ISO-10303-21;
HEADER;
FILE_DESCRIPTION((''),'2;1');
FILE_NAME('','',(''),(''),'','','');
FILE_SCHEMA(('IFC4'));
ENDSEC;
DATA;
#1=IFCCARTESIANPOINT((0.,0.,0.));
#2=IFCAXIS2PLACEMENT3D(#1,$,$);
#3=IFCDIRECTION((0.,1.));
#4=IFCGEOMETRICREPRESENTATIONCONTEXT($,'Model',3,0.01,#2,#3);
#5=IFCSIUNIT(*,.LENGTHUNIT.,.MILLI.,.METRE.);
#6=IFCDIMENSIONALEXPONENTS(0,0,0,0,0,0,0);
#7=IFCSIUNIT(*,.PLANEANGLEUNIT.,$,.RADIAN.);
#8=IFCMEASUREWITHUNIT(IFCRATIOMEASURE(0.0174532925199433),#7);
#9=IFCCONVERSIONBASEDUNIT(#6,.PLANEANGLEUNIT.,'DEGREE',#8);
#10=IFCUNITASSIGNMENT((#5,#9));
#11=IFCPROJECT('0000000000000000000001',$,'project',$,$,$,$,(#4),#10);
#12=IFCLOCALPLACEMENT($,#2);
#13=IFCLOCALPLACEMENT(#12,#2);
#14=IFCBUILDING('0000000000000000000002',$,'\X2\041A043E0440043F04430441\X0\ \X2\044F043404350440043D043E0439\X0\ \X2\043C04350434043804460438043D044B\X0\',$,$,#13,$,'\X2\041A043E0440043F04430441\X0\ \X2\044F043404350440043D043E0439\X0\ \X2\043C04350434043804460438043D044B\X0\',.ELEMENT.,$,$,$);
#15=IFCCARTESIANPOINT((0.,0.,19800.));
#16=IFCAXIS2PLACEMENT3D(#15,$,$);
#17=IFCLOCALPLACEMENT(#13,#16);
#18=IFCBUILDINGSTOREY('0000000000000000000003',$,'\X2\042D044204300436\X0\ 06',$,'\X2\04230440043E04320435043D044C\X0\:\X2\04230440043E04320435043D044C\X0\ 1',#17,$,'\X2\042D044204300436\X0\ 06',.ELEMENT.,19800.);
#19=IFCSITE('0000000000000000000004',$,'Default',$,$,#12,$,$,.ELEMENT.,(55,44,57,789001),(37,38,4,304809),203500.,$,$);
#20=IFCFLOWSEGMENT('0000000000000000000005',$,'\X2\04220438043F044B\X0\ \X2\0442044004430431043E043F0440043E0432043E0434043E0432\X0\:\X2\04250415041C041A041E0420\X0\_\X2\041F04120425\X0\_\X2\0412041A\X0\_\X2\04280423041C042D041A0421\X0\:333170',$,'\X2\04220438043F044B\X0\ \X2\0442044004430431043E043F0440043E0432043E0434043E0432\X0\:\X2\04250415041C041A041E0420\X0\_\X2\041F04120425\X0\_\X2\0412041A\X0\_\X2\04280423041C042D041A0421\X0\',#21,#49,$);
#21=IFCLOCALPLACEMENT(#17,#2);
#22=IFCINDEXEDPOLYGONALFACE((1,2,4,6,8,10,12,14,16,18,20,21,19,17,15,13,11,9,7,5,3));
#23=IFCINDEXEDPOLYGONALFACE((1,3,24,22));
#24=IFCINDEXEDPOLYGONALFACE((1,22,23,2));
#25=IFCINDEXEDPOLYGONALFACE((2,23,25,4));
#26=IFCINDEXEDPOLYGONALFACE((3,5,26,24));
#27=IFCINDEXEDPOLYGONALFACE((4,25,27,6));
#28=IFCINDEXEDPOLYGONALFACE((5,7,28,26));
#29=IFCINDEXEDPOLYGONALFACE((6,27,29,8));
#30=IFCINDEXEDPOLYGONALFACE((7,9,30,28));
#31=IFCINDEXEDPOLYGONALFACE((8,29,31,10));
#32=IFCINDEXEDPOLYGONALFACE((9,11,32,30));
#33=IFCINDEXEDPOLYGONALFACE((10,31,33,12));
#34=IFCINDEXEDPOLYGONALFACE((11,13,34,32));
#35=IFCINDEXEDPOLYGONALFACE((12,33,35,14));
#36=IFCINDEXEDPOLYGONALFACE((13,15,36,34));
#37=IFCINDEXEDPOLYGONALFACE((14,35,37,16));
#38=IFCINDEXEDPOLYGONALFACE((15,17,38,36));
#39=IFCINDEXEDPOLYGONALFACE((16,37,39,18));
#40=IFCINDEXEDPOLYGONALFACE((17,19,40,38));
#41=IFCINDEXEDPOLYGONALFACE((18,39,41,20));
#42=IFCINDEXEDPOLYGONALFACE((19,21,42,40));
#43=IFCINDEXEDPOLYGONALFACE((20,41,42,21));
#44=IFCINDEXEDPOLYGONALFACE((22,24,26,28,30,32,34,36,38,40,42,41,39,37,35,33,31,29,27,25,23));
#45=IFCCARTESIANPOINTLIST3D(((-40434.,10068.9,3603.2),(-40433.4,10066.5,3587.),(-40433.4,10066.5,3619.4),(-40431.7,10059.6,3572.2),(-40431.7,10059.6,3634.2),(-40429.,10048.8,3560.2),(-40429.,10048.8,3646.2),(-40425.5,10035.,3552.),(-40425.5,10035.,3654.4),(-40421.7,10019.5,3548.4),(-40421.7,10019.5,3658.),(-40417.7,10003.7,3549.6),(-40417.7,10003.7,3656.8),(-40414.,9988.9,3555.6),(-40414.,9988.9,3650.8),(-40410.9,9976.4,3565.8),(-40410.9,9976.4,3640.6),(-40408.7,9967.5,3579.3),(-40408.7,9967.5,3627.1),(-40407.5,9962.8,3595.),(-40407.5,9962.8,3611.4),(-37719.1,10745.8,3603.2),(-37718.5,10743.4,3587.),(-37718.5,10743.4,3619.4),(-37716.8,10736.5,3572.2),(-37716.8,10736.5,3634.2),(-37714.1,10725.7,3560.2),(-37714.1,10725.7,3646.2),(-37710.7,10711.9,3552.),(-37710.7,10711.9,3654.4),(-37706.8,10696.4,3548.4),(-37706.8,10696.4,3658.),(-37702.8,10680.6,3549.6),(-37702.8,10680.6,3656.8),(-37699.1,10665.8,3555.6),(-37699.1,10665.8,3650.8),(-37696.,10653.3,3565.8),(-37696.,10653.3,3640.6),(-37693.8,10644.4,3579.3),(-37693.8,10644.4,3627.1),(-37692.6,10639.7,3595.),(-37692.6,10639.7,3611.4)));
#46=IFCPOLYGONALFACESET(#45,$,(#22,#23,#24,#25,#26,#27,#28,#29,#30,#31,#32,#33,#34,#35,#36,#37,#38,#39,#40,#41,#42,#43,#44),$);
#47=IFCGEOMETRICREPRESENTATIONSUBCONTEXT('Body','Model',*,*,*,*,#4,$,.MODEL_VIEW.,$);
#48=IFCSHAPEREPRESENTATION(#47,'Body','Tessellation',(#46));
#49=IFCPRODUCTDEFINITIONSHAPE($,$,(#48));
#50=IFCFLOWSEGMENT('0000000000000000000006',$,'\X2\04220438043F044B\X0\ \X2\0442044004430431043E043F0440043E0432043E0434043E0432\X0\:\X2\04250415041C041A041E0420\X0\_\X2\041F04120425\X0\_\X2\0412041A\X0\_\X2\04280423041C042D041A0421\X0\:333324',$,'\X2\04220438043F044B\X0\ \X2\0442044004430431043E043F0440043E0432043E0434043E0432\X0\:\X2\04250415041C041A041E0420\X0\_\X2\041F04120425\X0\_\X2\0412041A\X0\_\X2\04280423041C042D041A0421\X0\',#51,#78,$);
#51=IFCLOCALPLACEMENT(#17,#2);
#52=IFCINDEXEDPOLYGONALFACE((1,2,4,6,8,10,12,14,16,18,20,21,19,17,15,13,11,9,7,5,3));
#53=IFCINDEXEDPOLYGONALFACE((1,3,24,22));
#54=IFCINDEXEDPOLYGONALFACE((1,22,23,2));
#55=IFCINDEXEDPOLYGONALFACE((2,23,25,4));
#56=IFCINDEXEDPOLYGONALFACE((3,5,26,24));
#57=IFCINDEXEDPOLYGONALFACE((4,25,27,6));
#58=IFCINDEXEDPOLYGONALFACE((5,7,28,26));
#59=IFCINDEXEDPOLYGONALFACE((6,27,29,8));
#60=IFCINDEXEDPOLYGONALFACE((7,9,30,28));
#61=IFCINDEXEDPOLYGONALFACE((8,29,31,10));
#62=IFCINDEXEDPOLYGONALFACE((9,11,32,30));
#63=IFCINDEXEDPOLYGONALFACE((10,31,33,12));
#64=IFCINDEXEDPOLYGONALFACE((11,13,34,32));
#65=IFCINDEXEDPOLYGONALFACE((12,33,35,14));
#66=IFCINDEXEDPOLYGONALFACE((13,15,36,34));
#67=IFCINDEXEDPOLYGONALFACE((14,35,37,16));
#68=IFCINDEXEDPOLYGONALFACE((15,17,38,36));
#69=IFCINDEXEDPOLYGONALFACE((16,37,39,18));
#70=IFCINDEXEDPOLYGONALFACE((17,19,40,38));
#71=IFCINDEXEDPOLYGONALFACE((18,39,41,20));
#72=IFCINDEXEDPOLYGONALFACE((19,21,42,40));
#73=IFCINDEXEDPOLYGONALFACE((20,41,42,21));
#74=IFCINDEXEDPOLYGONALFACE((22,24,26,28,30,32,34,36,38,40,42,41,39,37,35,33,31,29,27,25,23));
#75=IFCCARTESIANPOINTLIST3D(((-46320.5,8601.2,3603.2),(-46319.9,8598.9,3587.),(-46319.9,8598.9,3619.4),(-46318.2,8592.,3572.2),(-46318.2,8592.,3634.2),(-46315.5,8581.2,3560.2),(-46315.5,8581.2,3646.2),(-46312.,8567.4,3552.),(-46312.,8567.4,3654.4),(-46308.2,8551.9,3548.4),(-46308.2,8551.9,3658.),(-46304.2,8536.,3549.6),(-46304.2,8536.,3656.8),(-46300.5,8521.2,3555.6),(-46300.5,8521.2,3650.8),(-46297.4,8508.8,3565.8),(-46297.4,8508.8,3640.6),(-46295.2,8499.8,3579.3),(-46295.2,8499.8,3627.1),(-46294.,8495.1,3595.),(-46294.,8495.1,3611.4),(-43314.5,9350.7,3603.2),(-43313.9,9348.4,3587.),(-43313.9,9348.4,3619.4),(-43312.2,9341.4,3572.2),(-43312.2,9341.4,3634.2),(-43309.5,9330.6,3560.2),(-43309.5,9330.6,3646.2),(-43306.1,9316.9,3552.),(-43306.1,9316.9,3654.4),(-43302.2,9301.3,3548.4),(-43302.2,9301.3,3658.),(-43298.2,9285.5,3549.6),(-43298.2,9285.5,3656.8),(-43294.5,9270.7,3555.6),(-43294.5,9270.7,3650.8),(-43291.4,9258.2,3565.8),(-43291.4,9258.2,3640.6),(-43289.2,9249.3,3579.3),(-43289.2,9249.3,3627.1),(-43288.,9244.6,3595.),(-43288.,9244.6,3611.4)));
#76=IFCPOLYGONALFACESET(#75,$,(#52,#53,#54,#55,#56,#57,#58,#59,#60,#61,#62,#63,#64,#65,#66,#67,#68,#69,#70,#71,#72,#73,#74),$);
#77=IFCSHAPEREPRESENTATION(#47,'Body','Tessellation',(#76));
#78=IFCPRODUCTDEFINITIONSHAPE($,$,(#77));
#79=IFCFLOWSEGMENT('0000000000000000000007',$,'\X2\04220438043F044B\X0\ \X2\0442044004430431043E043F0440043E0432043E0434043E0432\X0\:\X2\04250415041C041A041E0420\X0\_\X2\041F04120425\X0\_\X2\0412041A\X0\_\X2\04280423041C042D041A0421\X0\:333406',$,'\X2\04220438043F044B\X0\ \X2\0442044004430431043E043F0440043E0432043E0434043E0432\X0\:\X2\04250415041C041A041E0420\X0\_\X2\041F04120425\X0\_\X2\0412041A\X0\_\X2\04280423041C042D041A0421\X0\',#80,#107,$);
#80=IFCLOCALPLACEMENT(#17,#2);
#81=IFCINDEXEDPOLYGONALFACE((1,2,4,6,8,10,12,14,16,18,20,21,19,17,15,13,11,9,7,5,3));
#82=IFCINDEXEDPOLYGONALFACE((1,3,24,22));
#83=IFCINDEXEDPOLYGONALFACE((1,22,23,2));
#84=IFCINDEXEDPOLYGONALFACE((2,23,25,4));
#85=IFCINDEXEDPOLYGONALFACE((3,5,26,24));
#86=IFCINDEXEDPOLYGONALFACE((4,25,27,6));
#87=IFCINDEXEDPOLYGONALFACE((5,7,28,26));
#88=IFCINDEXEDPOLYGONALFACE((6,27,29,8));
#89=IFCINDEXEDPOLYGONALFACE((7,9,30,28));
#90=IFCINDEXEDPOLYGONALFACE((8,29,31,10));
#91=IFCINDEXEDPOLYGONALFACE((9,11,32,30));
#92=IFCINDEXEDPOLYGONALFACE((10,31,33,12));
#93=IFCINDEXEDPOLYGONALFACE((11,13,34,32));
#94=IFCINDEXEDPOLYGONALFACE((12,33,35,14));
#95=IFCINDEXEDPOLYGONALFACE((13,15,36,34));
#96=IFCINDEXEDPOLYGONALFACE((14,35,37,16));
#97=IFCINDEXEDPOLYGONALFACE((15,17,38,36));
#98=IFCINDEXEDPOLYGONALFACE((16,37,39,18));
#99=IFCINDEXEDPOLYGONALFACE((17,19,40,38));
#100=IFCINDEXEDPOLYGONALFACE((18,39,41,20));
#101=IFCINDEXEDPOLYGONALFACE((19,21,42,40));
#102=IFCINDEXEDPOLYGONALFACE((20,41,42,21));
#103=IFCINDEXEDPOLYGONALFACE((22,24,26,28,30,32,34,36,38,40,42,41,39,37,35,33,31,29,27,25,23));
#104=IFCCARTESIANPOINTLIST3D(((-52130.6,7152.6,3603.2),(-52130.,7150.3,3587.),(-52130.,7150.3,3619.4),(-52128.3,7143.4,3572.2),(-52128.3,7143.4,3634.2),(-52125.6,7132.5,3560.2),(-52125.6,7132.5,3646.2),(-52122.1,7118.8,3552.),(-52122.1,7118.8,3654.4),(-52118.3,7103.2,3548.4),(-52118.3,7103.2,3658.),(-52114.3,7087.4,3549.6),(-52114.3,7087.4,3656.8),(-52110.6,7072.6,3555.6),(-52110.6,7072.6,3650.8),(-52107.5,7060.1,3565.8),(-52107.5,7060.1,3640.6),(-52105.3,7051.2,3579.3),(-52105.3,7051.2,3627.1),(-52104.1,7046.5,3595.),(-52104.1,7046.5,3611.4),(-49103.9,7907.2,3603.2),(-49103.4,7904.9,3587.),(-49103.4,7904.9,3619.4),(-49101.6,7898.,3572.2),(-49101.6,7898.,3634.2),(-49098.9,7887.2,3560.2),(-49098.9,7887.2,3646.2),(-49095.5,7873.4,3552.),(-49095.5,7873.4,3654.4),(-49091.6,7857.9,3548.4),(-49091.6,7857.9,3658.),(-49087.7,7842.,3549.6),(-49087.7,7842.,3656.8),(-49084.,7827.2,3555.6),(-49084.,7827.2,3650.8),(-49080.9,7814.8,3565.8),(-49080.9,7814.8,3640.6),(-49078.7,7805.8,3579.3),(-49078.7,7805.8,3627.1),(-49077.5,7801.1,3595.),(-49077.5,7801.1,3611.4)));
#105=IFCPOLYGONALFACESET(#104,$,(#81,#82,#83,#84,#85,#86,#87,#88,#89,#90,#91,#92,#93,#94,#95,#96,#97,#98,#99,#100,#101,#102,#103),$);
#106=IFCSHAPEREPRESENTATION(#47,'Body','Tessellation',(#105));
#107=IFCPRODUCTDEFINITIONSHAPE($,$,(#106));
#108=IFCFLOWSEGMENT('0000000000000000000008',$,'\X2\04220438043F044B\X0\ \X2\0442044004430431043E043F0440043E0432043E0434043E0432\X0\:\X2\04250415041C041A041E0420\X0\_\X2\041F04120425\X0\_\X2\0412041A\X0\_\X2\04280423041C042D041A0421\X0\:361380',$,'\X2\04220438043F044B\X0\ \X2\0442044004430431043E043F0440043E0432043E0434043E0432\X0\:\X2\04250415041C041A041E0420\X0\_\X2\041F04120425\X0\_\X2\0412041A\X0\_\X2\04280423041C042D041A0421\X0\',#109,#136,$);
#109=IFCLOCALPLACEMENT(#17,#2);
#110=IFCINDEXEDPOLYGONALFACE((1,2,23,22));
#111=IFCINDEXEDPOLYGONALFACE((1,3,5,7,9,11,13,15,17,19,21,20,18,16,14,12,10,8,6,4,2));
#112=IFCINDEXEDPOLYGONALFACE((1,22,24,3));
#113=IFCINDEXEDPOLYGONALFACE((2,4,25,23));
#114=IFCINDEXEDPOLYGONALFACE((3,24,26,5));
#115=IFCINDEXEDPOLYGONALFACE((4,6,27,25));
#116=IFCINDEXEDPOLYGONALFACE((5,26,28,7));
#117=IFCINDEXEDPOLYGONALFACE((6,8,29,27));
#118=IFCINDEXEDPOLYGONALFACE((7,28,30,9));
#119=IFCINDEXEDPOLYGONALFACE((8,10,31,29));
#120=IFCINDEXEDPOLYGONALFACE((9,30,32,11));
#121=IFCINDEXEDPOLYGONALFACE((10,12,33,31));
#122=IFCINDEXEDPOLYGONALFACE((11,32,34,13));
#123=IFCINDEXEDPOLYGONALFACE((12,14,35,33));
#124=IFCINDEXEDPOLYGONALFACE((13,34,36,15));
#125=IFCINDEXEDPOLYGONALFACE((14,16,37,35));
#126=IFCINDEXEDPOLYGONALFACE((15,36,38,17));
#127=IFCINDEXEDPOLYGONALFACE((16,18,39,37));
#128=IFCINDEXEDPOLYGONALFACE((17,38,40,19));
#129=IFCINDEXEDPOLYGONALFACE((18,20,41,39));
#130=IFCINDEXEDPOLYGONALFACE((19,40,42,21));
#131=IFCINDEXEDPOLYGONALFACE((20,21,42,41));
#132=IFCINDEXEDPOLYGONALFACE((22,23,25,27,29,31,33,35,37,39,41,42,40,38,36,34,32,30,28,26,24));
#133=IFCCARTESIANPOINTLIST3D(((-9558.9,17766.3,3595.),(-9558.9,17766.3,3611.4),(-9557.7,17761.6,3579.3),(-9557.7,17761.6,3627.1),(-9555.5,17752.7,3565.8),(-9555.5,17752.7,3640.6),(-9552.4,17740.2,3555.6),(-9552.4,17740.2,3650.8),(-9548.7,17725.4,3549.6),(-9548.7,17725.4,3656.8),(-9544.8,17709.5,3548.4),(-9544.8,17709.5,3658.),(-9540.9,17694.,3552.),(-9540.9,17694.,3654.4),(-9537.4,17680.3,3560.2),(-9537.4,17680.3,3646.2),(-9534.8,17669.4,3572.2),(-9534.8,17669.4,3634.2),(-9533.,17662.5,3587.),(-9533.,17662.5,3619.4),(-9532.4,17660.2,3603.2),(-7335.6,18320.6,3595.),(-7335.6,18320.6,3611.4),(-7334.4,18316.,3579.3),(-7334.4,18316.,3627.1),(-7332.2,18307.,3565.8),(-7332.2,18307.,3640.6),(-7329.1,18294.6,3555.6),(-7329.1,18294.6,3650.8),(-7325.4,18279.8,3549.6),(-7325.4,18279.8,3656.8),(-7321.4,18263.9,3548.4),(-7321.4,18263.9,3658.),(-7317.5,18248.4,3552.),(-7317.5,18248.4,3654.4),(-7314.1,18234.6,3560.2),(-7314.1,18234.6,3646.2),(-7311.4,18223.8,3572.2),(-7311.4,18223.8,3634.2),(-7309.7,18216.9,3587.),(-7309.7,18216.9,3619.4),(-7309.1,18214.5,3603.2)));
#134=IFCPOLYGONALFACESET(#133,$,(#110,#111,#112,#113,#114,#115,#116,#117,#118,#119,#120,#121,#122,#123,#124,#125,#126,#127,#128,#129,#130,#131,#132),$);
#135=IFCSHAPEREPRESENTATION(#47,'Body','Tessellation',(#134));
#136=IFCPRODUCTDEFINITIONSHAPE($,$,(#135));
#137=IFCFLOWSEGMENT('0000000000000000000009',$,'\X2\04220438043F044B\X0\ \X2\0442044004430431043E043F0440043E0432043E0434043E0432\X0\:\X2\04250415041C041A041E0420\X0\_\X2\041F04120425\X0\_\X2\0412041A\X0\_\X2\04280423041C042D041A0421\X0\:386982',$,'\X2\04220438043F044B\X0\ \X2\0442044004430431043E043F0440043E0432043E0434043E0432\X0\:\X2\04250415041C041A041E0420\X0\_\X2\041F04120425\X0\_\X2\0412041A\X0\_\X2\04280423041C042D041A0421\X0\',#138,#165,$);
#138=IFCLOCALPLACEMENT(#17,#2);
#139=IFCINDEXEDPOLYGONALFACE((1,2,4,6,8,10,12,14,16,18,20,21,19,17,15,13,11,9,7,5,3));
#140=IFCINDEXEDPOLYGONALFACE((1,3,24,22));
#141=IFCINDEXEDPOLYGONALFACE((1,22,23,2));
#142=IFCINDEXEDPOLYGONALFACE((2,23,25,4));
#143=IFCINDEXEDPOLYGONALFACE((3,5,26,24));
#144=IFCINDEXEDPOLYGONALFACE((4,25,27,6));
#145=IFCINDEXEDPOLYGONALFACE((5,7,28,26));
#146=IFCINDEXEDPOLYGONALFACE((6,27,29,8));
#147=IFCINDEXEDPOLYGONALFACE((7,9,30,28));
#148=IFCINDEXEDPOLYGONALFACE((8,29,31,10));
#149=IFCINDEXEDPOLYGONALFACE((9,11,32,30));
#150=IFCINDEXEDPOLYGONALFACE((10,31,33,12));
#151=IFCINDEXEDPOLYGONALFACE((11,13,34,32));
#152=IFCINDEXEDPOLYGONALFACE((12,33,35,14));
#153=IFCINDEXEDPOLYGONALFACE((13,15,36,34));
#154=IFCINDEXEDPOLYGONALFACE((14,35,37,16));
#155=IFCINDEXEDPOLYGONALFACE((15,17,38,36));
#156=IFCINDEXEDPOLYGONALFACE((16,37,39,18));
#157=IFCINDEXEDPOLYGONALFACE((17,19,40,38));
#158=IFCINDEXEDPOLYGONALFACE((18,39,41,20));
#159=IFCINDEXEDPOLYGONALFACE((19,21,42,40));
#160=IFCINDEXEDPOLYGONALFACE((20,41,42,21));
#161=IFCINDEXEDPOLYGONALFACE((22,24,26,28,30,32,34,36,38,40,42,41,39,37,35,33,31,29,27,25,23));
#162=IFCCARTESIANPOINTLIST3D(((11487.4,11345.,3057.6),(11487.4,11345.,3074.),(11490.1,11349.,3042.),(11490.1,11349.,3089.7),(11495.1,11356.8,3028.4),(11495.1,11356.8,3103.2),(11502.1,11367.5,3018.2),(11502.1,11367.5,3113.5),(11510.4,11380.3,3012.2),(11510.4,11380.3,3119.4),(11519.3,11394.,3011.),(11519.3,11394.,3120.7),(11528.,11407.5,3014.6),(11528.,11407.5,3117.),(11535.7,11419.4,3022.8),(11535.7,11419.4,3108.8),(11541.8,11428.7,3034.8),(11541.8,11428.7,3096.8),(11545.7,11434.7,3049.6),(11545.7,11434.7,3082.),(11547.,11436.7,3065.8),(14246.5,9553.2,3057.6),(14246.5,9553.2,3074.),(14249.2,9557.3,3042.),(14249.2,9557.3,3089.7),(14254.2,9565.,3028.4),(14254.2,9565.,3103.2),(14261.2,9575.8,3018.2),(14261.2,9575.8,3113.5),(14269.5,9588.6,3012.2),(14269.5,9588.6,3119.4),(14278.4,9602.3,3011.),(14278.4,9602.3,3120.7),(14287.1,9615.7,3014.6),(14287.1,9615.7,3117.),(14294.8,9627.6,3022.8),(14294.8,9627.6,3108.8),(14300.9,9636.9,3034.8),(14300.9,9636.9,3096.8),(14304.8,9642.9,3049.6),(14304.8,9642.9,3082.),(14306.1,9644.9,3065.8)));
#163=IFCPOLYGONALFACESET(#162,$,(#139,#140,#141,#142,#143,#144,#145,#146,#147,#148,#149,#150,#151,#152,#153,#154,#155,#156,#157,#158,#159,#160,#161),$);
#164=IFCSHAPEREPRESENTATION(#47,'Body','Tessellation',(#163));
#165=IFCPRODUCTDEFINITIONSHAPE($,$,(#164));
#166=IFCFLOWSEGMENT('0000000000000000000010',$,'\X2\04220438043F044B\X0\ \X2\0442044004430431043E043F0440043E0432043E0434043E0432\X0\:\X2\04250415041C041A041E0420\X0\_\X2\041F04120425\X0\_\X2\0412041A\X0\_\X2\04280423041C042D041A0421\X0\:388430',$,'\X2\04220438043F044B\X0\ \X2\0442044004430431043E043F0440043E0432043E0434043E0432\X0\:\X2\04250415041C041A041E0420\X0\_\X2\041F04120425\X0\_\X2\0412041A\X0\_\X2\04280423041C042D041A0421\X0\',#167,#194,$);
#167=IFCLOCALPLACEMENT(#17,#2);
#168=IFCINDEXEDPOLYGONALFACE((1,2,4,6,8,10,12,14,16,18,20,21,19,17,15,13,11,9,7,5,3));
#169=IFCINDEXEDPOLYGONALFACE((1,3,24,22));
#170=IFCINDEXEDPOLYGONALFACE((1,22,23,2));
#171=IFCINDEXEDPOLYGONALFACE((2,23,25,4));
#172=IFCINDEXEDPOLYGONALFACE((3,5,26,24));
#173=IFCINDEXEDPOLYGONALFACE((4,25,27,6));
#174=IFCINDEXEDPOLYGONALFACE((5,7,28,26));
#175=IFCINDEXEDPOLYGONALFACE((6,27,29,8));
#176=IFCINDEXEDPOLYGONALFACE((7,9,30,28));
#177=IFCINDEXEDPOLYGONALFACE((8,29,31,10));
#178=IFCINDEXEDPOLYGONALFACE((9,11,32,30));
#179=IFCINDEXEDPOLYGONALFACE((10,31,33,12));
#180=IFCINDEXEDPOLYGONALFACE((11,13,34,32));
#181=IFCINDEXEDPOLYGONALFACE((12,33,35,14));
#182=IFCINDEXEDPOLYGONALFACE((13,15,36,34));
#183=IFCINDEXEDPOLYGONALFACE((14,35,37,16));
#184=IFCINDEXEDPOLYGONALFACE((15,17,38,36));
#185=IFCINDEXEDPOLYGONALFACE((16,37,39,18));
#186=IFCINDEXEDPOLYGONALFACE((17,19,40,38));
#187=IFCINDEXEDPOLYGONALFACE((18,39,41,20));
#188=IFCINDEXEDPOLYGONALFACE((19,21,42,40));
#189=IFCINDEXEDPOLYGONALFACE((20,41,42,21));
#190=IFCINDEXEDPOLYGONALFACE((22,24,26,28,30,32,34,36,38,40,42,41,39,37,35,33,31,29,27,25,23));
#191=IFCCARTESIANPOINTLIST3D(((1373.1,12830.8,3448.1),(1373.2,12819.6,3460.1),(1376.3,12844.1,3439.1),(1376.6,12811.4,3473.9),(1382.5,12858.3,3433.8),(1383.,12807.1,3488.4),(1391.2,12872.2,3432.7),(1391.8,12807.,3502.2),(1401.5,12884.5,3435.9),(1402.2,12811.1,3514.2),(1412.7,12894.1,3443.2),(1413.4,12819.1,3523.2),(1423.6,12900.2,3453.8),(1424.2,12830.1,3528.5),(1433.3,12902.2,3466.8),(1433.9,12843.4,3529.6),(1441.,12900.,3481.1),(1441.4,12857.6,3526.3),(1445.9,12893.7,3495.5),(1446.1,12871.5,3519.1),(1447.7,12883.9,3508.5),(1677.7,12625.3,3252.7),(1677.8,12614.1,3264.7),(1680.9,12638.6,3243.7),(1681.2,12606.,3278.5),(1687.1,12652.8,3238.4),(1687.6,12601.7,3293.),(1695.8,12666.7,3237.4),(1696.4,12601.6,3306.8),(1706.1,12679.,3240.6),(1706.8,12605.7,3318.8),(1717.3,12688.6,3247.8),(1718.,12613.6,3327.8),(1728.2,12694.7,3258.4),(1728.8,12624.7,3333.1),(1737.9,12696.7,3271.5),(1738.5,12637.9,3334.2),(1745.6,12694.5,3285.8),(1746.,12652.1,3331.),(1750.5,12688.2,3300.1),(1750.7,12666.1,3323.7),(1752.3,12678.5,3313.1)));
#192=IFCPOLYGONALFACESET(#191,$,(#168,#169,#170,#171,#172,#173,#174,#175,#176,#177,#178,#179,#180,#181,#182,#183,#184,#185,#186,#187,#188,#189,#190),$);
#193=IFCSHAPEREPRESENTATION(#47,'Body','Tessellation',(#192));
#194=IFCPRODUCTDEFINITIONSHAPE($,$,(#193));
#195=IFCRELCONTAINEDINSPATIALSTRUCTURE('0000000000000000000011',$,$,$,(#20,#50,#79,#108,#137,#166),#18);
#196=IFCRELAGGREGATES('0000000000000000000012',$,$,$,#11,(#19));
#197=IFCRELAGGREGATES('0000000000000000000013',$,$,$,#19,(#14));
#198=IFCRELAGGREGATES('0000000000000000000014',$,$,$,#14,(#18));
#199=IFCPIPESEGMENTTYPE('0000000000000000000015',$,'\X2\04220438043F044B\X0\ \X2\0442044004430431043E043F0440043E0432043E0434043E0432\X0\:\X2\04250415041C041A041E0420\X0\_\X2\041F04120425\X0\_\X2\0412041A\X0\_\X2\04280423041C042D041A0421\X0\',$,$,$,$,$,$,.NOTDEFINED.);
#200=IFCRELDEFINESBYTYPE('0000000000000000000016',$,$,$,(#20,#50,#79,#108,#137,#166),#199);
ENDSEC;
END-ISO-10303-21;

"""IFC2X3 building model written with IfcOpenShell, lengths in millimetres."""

from ifc_helpers import new_model, entity, si_unit, converted_unit, direction, frame, frame_2d, origin, origin_2d_with_axis, place, context, subcontext, project, spatial, circle, extrude, type_object, element, save


model = new_model("IFC2X3")

# Units and contexts
model_context = context("Model", 3, precision=0.01, world=origin(), true_north=direction((0.0, 1.0)))
body_context = subcontext(model_context, "Body", "Model", "MODEL_VIEW")
ifc_project = project(units=[si_unit("LENGTHUNIT", "METRE", prefix="MILLI"), converted_unit("PLANEANGLEUNIT", "DEGREE", entity("IfcRatioMeasure", 0.0174532925199433), si_unit("PLANEANGLEUNIT", "RADIAN"), dimensions=[0, 0, 0, 0, 0, 0, 0])], contexts=[model_context])

# Site, building, storey
site_placement = place(None, frame((0.0, 0.0, 0.0)))
site = spatial("IfcSite", under=ifc_project, at=site_placement, Name="Default", CompositionType="ELEMENT", RefLatitude=(55, 44, 57, 789001), RefLongitude=(37, 38, 4, 304809), RefElevation=203500.0)
building_placement = place(site_placement, origin())
building = spatial("IfcBuilding", under=site, at=building_placement, Name="Корпус ядерной медицины", LongName="Корпус ядерной медицины", CompositionType="ELEMENT")
storey_placement = place(building_placement, frame((0.0, 0.0, 19800.0)))
storey = spatial("IfcBuildingStorey", under=building, at=storey_placement, Name="Этаж 06", ObjectType="Уровень:Уровень 1", LongName="Этаж 06", CompositionType="ELEMENT", Elevation=19800.0)

# Flow segments
pipe_segment_type = type_object("IfcPipeSegmentType", Name="Типы трубопроводов:ХЕМКОР_ПВХ_ВК_ШУМЭКС", PredefinedType="NOTDEFINED")
flow_segment_1_placement = place(storey_placement, frame((-40435.6, 9960.6, 3546.6)))
element("IfcFlowSegment", 1, at=flow_segment_1_placement, inside=storey, type_object=pipe_segment_type, Name="Типы трубопроводов:ХЕМКОР_ПВХ_ВК_ШУМЭКС:333170", ObjectType="Типы трубопроводов:ХЕМКОР_ПВХ_ВК_ШУМЭКС", context=body_context, shape_type="SweptSolid", body=[
    extrude(circle(Radius=55.0, at=origin_2d_with_axis()), frame((14.9, 55.0, 56.6), z_axis=(0.970296, 0.241922, 0.0), x_axis=(-0.241922, 0.970296, 0.0)), (0.0, 0.0, 1.0), 2798.0),
])
flow_segment_2_placement = place(storey_placement, frame((-46322.1, 8492.9, 3546.6)))
element("IfcFlowSegment", 2, at=flow_segment_2_placement, inside=storey, type_object=pipe_segment_type, Name="Типы трубопроводов:ХЕМКОР_ПВХ_ВК_ШУМЭКС:333324", ObjectType="Типы трубопроводов:ХЕМКОР_ПВХ_ВК_ШУМЭКС", context=body_context, shape_type="SweptSolid", body=[
    extrude(circle(Radius=55.0, at=frame_2d((0.0, 0.0), x_axis=(1.0, 0.0))), frame((14.9, 55.0, 56.6), z_axis=(0.970296, 0.241922, 0.0), x_axis=(-0.241922, 0.970296, 0.0)), (0.0, 0.0, 1.0), 3098.0),
])
flow_segment_3_placement = place(storey_placement, frame((-52132.2, 7044.3, 3546.6)))
element("IfcFlowSegment", 3, at=flow_segment_3_placement, inside=storey, type_object=pipe_segment_type, Name="Типы трубопроводов:ХЕМКОР_ПВХ_ВК_ШУМЭКС:333406", ObjectType="Типы трубопроводов:ХЕМКОР_ПВХ_ВК_ШУМЭКС", context=body_context, shape_type="SweptSolid", body=[
    extrude(circle(Radius=55.0, at=origin_2d_with_axis()), frame((14.9, 55.0, 56.6), z_axis=(0.970296, 0.241922, 0.0), x_axis=(-0.241922, 0.970296, 0.0)), (0.0, 0.0, 1.0), 3119.3),
])
flow_segment_4_placement = place(storey_placement, frame((-9560.6, 17658.6, 3546.6)))
element("IfcFlowSegment", 4, at=flow_segment_4_placement, inside=storey, type_object=pipe_segment_type, Name="Типы трубопроводов:ХЕМКОР_ПВХ_ВК_ШУМЭКС:361380", ObjectType="Типы трубопроводов:ХЕМКОР_ПВХ_ВК_ШУМЭКС", context=body_context, shape_type="SweptSolid", body=[
    extrude(circle(Radius=55.0, at=origin_2d_with_axis()), frame((14.9, 55.0, 56.6), z_axis=(0.970296, 0.241922, 0.0), x_axis=(0.241922, -0.970296, 0.0)), (0.0, 0.0, 1.0), 2291.4),
])
flow_segment_5_placement = place(storey_placement, frame((11485.5, 9551.1, 3009.2)))
element("IfcFlowSegment", 5, at=flow_segment_5_placement, inside=storey, type_object=pipe_segment_type, Name="Типы трубопроводов:ХЕМКОР_ПВХ_ВК_ШУМЭКС:386982", ObjectType="Типы трубопроводов:ХЕМКОР_ПВХ_ВК_ШУМЭКС", context=body_context, shape_type="SweptSolid", body=[
    extrude(circle(Radius=55.0, at=origin_2d_with_axis()), frame((2790.7, 47.7, 56.6), z_axis=(-0.838671, 0.544639, 0.0), x_axis=(0.544639, 0.838671, 0.0)), (0.0, 0.0, 1.0), 3289.9),
])
flow_segment_6_placement = place(storey_placement, frame((1371.3, 12599.5, 3235.6)))
element("IfcFlowSegment", 6, at=flow_segment_6_placement, inside=storey, type_object=pipe_segment_type, Name="Типы трубопроводов:ХЕМКОР_ПВХ_ВК_ШУМЭКС:388430", ObjectType="Типы трубопроводов:ХЕМКОР_ПВХ_ВК_ШУМЭКС", context=body_context, shape_type="SweptSolid", body=[
    extrude(circle(Radius=55.0, at=origin_2d_with_axis()), frame((38.9, 254.8, 245.5), z_axis=(0.731997, -0.493738, -0.469472), x_axis=(0.559193, 0.829038, 0.0)), (0.0, 0.0, 1.0), 416.1),
])

save(model, "model.ifc")
